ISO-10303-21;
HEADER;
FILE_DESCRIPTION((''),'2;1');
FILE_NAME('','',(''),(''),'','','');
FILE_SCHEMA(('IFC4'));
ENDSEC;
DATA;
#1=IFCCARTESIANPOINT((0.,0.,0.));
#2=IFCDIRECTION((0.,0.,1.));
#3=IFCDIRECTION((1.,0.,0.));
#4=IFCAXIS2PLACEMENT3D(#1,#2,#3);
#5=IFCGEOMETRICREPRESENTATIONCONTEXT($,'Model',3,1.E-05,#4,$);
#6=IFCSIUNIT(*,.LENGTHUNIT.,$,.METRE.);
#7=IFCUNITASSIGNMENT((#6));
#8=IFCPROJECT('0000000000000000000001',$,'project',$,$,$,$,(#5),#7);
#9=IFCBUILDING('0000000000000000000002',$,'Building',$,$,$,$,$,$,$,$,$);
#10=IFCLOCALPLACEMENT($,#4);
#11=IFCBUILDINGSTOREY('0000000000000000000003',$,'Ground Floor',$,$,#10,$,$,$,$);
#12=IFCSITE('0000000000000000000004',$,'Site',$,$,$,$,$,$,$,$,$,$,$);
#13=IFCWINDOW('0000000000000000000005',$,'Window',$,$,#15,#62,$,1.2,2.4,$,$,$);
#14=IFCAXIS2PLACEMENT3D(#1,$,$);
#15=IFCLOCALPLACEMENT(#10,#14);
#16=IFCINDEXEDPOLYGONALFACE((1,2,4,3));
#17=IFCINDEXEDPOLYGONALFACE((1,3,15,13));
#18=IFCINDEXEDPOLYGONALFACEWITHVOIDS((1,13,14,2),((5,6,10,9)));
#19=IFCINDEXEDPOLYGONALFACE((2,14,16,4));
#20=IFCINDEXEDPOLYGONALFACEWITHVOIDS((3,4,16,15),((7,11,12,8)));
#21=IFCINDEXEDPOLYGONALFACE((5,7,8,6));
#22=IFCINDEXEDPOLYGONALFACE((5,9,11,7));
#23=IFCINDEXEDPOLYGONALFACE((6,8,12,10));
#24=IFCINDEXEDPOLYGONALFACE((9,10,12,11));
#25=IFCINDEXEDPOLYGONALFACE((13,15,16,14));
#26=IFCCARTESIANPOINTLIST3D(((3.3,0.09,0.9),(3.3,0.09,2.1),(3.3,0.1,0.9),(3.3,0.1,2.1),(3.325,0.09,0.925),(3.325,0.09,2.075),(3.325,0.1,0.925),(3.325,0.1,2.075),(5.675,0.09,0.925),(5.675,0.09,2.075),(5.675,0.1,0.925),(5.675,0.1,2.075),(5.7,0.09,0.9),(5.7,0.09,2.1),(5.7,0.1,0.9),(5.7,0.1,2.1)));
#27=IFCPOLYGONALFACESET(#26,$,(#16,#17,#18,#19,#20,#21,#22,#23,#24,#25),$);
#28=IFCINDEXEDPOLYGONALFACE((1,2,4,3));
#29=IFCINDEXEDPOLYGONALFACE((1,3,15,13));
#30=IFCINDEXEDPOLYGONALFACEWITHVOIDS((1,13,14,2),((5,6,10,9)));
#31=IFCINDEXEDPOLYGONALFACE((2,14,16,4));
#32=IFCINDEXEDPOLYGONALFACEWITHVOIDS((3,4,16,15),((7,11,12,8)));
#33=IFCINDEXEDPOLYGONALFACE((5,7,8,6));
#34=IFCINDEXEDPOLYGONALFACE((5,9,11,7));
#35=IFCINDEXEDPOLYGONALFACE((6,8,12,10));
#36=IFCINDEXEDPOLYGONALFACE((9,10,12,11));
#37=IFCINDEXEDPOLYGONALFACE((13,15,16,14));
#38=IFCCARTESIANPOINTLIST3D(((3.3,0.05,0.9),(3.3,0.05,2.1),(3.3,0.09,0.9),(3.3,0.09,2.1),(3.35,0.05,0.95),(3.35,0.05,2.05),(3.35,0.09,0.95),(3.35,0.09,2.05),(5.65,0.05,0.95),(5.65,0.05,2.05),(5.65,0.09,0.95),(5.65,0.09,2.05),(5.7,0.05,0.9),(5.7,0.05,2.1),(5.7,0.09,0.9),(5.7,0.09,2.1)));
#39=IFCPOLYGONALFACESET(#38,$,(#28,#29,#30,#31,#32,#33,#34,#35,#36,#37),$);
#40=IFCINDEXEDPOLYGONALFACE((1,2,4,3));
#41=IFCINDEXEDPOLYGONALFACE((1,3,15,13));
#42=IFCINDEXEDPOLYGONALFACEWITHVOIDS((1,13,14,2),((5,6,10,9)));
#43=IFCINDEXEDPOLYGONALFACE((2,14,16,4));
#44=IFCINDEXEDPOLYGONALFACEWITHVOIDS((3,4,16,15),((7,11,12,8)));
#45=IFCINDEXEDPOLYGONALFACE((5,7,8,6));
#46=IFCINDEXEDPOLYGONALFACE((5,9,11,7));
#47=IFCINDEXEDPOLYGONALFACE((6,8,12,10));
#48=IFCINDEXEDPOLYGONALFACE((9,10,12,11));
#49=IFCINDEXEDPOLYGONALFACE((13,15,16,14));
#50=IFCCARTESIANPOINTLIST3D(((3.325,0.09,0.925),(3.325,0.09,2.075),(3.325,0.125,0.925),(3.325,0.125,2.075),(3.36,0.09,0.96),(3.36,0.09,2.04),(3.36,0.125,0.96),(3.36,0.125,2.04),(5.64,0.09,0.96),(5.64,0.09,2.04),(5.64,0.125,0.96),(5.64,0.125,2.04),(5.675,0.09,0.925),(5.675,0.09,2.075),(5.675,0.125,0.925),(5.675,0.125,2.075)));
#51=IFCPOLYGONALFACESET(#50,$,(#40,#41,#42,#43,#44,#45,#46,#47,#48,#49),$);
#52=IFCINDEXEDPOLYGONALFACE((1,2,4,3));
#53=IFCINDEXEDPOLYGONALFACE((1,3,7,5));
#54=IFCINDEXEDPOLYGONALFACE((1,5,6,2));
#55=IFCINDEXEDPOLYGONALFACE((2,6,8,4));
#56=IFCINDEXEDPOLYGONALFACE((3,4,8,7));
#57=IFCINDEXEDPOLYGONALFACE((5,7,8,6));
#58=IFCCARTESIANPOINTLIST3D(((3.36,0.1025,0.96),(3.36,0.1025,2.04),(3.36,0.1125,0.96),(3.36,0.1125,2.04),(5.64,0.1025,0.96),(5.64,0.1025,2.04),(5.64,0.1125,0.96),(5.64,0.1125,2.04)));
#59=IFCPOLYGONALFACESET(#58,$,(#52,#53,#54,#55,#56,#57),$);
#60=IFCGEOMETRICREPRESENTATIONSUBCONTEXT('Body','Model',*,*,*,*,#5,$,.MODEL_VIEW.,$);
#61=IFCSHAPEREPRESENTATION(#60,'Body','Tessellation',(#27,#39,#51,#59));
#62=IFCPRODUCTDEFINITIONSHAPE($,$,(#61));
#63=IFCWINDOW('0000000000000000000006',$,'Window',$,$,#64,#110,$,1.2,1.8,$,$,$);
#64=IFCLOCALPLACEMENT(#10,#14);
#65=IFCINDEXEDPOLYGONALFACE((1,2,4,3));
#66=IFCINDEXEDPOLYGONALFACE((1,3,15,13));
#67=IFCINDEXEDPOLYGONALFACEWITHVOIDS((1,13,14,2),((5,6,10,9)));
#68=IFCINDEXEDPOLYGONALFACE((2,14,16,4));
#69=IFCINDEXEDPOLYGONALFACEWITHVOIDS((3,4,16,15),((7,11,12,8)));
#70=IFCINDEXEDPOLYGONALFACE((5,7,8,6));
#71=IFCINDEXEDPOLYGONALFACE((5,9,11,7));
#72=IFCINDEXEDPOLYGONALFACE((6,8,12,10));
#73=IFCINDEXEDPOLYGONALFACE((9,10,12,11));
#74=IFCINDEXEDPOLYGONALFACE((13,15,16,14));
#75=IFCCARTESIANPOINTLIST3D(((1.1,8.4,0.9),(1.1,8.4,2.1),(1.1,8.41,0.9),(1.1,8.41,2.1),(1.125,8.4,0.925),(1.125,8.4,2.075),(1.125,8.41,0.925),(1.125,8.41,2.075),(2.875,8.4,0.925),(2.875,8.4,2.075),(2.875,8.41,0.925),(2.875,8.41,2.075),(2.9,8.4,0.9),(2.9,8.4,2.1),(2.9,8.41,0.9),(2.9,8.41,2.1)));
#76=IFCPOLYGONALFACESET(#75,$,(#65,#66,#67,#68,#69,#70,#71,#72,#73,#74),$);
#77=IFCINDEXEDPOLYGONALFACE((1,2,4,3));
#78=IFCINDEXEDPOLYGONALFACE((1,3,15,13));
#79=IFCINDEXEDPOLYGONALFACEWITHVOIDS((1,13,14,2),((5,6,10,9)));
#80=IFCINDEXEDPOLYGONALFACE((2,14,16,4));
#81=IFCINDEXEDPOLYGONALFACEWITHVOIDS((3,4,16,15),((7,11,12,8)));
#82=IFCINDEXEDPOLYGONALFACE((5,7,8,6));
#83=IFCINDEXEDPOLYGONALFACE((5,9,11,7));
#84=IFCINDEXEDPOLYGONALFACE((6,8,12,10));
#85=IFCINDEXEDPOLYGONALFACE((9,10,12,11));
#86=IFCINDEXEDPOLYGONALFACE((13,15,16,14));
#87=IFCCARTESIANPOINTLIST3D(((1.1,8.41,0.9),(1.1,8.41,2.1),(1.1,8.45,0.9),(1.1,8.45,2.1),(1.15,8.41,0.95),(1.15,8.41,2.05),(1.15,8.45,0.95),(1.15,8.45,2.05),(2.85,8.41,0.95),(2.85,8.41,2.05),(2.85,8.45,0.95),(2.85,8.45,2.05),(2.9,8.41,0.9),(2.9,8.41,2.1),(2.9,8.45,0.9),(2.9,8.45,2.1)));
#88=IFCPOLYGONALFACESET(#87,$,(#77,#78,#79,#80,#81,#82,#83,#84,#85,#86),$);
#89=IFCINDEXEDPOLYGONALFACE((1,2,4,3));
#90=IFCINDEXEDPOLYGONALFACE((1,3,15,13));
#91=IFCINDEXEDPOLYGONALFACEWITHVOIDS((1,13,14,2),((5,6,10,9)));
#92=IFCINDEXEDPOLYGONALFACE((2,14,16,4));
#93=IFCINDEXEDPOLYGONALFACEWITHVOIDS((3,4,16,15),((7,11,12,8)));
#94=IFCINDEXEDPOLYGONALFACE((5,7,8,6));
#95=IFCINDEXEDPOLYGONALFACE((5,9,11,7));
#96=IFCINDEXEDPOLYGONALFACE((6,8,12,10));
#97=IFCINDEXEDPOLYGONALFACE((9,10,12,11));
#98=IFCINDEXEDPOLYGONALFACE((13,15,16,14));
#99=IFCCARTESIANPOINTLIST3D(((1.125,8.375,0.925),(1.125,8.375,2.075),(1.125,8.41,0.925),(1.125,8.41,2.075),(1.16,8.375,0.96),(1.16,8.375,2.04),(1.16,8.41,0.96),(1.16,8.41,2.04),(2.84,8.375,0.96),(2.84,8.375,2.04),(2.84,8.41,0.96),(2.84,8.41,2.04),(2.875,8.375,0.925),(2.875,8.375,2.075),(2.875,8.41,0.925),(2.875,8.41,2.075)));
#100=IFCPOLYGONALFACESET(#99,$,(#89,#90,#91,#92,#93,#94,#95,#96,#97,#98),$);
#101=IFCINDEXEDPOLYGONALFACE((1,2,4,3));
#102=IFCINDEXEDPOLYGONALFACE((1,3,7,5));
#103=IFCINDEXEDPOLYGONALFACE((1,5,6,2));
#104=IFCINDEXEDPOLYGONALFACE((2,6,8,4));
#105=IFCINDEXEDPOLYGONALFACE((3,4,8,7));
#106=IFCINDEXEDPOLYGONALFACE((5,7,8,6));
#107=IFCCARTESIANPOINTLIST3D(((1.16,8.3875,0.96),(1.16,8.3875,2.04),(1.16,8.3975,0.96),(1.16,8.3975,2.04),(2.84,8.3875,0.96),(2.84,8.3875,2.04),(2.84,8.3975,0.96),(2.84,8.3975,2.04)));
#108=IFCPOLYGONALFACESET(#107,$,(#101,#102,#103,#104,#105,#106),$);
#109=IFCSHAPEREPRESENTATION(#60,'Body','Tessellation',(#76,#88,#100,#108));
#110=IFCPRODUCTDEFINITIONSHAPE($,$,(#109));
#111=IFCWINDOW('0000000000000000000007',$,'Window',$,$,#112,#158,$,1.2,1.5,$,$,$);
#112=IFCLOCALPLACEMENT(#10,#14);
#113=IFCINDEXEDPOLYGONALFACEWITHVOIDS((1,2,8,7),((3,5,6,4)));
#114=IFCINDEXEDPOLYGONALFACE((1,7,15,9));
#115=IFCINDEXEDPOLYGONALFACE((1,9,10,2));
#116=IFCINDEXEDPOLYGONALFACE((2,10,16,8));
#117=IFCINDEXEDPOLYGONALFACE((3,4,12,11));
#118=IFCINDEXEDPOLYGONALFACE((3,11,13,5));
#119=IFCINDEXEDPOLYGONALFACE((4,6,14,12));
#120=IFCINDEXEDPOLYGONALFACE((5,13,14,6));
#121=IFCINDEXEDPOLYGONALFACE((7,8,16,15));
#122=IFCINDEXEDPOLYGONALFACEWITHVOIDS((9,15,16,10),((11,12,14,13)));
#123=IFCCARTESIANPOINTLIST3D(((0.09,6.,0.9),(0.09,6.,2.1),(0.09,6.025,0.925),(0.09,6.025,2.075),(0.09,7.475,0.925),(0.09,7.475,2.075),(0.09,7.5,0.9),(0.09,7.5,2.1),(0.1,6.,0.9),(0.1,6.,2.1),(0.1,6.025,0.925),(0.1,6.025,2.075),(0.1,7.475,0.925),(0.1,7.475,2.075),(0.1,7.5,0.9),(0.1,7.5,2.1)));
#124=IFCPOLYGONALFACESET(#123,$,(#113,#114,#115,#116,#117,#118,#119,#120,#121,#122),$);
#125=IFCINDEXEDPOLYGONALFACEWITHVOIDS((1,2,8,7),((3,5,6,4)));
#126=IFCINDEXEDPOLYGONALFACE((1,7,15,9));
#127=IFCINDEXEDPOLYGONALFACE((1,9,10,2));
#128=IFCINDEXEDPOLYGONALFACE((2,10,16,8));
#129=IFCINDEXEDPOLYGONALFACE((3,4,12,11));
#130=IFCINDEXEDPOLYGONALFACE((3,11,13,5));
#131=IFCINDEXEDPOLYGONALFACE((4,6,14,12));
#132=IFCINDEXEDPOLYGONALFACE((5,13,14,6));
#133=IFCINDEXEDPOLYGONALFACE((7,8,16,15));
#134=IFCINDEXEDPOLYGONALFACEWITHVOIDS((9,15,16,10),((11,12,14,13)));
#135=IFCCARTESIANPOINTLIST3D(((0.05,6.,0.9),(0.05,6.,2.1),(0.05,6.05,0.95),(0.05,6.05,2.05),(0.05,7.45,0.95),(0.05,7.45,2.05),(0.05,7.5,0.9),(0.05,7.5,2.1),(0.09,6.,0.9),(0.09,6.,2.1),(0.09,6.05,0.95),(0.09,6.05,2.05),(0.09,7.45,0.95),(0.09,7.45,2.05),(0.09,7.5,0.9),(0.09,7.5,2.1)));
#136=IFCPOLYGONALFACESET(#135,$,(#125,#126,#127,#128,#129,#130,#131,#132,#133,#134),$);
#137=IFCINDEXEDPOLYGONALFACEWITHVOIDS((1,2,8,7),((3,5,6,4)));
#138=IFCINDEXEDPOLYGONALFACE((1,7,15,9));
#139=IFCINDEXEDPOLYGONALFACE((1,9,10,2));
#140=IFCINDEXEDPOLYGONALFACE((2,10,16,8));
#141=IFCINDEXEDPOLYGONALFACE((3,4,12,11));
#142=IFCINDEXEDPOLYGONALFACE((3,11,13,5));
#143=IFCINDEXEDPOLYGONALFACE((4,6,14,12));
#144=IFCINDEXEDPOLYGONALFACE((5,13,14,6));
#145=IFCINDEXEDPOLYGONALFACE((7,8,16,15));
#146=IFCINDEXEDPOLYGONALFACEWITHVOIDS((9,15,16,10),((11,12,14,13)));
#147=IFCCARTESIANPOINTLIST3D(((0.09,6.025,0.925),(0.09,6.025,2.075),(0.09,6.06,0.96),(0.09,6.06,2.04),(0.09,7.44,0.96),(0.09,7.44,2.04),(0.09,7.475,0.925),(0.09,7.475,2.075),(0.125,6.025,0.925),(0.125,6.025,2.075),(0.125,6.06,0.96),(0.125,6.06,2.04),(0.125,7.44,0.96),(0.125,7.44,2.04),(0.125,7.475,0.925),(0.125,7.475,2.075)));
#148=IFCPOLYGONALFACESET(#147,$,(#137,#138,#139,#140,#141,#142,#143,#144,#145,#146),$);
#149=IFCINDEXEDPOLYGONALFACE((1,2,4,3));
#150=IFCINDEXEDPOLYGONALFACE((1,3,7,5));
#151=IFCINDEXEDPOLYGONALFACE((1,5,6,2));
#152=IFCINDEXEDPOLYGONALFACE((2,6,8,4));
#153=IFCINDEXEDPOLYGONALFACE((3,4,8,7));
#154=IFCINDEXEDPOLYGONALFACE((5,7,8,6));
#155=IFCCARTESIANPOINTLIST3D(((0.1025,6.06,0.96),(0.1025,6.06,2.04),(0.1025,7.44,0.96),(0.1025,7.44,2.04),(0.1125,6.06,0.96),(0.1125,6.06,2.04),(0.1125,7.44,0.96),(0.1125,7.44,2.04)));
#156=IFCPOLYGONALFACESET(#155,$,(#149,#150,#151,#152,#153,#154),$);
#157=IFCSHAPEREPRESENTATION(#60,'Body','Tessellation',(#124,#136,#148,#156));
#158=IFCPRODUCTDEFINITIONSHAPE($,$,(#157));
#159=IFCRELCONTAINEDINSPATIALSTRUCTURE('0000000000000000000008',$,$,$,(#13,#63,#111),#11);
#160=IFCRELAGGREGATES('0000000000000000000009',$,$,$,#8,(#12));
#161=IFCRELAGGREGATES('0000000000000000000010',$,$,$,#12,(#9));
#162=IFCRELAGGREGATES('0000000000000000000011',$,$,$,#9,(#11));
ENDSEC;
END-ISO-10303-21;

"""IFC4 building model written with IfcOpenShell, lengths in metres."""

from ifc_helpers import new_model, si_unit, frame, origin_with_axes, place, context, subcontext, project, spatial, line, indexed_curve, outline, extrude, element, save


model = new_model("IFC4")

# Units and contexts
model_context = context("Model", 3, precision=1e-05, world=origin_with_axes())
body_context = subcontext(model_context, "Body", "Model", "MODEL_VIEW")
ifc_project = project(units=[si_unit("LENGTHUNIT", "METRE")], contexts=[model_context])

# Site, building, storey
site = spatial("IfcSite", under=ifc_project, Name="Site")
building = spatial("IfcBuilding", under=site, Name="Building")
storey_placement = place(None, origin_with_axes())
storey = spatial("IfcBuildingStorey", under=building, at=storey_placement, Name="Ground Floor")

# Windows
window_1_placement = place(storey_placement, frame((3.3, 0.0, 0.9), z_axis=(0.0, 0.0, 1.0), x_axis=(1.0, 0.0, 0.0)))
element("IfcWindow", 1, at=window_1_placement, inside=storey, Name="Window", OverallHeight=1.2, OverallWidth=2.4, context=body_context, shape_type="SweptSolid", body=[
    extrude(outline(indexed_curve([(0.0, 0.0), (2.4, 0.0), (2.4, 1.2), (0.0, 1.2)], segments=[line(1, 2, 3, 4, 1)]), holes=[indexed_curve([(0.025, 0.025), (2.375, 0.025), (2.375, 1.175), (0.025, 1.175)], segments=[line(1, 2, 3, 4, 1)])]), frame((0.0, 0.09, 0.0), z_axis=(0.0, -1.0, 0.0), x_axis=(1.0, 0.0, 0.0)), (0.0, 0.0, -1.0), 0.01),
    extrude(outline(indexed_curve([(0.0, 0.0), (2.4, 0.0), (2.4, 1.2), (0.0, 1.2)], segments=[line(1, 2, 3, 4, 1)]), holes=[indexed_curve([(0.05, 0.05), (2.35, 0.05), (2.35, 1.15), (0.05, 1.15)], segments=[line(1, 2, 3, 4, 1)])]), frame((0.0, 0.05, 0.0), z_axis=(0.0, -1.0, 0.0), x_axis=(1.0, 0.0, 0.0)), (0.0, 0.0, -1.0), 0.04),
    extrude(outline(indexed_curve([(0.0, 0.0), (2.35, 0.0), (2.35, 1.15), (0.0, 1.15)], segments=[line(1, 2, 3, 4, 1)]), holes=[indexed_curve([(0.035, 0.035), (2.315, 0.035), (2.315, 1.115), (0.035, 1.115)], segments=[line(1, 2, 3, 4, 1)])]), frame((0.025, 0.09, 0.025), z_axis=(0.0, -1.0, 0.0), x_axis=(1.0, 0.0, 0.0)), (0.0, 0.0, -1.0), 0.035),
    extrude(outline(indexed_curve([(0.035, 0.035), (2.315, 0.035), (2.315, 1.115), (0.035, 1.115)], segments=[line(1, 2, 3, 4, 1)])), frame((0.025, 0.1025, 0.025), z_axis=(0.0, -1.0, 0.0), x_axis=(1.0, 0.0, 0.0)), (0.0, 0.0, -1.0), 0.01),
])
window_2_placement = place(storey_placement, frame((2.9, 8.5, 0.9), z_axis=(0.0, 0.0, 1.0), x_axis=(-1.0, 0.0, 0.0)))
element("IfcWindow", 2, at=window_2_placement, inside=storey, Name="Window", OverallHeight=1.2, OverallWidth=1.8, context=body_context, shape_type="SweptSolid", body=[
    extrude(outline(indexed_curve([(0.0, 0.0), (1.8, 0.0), (1.8, 1.2), (0.0, 1.2)], segments=[line(1, 2, 3, 4, 1)]), holes=[indexed_curve([(0.025, 0.025), (1.775, 0.025), (1.775, 1.175), (0.025, 1.175)], segments=[line(1, 2, 3, 4, 1)])]), frame((0.0, 0.09, 0.0), z_axis=(0.0, -1.0, 0.0), x_axis=(1.0, 0.0, 0.0)), (0.0, 0.0, -1.0), 0.01),
    extrude(outline(indexed_curve([(0.0, 0.0), (1.8, 0.0), (1.8, 1.2), (0.0, 1.2)], segments=[line(1, 2, 3, 4, 1)]), holes=[indexed_curve([(0.05, 0.05), (1.75, 0.05), (1.75, 1.15), (0.05, 1.15)], segments=[line(1, 2, 3, 4, 1)])]), frame((0.0, 0.05, 0.0), z_axis=(0.0, -1.0, 0.0), x_axis=(1.0, 0.0, 0.0)), (0.0, 0.0, -1.0), 0.04),
    extrude(outline(indexed_curve([(0.0, 0.0), (1.75, 0.0), (1.75, 1.15), (0.0, 1.15)], segments=[line(1, 2, 3, 4, 1)]), holes=[indexed_curve([(0.035, 0.035), (1.715, 0.035), (1.715, 1.115), (0.035, 1.115)], segments=[line(1, 2, 3, 4, 1)])]), frame((0.025, 0.09, 0.025), z_axis=(0.0, -1.0, 0.0), x_axis=(1.0, 0.0, 0.0)), (0.0, 0.0, -1.0), 0.035),
    extrude(outline(indexed_curve([(0.035, 0.035), (1.715, 0.035), (1.715, 1.115), (0.035, 1.115)], segments=[line(1, 2, 3, 4, 1)])), frame((0.025, 0.1025, 0.025), z_axis=(0.0, -1.0, 0.0), x_axis=(1.0, 0.0, 0.0)), (0.0, 0.0, -1.0), 0.01),
])
window_3_placement = place(storey_placement, frame((0.0, 7.5, 0.9), z_axis=(0.0, 0.0, 1.0), x_axis=(0.0, -1.0, 0.0)))
element("IfcWindow", 3, at=window_3_placement, inside=storey, Name="Window", OverallHeight=1.2, OverallWidth=1.5, context=body_context, shape_type="SweptSolid", body=[
    extrude(outline(indexed_curve([(0.0, 0.0), (1.5, 0.0), (1.5, 1.2), (0.0, 1.2)], segments=[line(1, 2, 3, 4, 1)]), holes=[indexed_curve([(0.025, 0.025), (1.475, 0.025), (1.475, 1.175), (0.025, 1.175)], segments=[line(1, 2, 3, 4, 1)])]), frame((0.0, 0.09, 0.0), z_axis=(0.0, -1.0, 0.0), x_axis=(1.0, 0.0, 0.0)), (0.0, 0.0, -1.0), 0.01),
    extrude(outline(indexed_curve([(0.0, 0.0), (1.5, 0.0), (1.5, 1.2), (0.0, 1.2)], segments=[line(1, 2, 3, 4, 1)]), holes=[indexed_curve([(0.05, 0.05), (1.45, 0.05), (1.45, 1.15), (0.05, 1.15)], segments=[line(1, 2, 3, 4, 1)])]), frame((0.0, 0.05, 0.0), z_axis=(0.0, -1.0, 0.0), x_axis=(1.0, 0.0, 0.0)), (0.0, 0.0, -1.0), 0.04),
    extrude(outline(indexed_curve([(0.0, 0.0), (1.45, 0.0), (1.45, 1.15), (0.0, 1.15)], segments=[line(1, 2, 3, 4, 1)]), holes=[indexed_curve([(0.035, 0.035), (1.415, 0.035), (1.415, 1.115), (0.035, 1.115)], segments=[line(1, 2, 3, 4, 1)])]), frame((0.025, 0.09, 0.025), z_axis=(0.0, -1.0, 0.0), x_axis=(1.0, 0.0, 0.0)), (0.0, 0.0, -1.0), 0.035),
    extrude(outline(indexed_curve([(0.035, 0.035), (1.415, 0.035), (1.415, 1.115), (0.035, 1.115)], segments=[line(1, 2, 3, 4, 1)])), frame((0.025, 0.1025, 0.025), z_axis=(0.0, -1.0, 0.0), x_axis=(1.0, 0.0, 0.0)), (0.0, 0.0, -1.0), 0.01),
])

save(model, "model.ifc")
